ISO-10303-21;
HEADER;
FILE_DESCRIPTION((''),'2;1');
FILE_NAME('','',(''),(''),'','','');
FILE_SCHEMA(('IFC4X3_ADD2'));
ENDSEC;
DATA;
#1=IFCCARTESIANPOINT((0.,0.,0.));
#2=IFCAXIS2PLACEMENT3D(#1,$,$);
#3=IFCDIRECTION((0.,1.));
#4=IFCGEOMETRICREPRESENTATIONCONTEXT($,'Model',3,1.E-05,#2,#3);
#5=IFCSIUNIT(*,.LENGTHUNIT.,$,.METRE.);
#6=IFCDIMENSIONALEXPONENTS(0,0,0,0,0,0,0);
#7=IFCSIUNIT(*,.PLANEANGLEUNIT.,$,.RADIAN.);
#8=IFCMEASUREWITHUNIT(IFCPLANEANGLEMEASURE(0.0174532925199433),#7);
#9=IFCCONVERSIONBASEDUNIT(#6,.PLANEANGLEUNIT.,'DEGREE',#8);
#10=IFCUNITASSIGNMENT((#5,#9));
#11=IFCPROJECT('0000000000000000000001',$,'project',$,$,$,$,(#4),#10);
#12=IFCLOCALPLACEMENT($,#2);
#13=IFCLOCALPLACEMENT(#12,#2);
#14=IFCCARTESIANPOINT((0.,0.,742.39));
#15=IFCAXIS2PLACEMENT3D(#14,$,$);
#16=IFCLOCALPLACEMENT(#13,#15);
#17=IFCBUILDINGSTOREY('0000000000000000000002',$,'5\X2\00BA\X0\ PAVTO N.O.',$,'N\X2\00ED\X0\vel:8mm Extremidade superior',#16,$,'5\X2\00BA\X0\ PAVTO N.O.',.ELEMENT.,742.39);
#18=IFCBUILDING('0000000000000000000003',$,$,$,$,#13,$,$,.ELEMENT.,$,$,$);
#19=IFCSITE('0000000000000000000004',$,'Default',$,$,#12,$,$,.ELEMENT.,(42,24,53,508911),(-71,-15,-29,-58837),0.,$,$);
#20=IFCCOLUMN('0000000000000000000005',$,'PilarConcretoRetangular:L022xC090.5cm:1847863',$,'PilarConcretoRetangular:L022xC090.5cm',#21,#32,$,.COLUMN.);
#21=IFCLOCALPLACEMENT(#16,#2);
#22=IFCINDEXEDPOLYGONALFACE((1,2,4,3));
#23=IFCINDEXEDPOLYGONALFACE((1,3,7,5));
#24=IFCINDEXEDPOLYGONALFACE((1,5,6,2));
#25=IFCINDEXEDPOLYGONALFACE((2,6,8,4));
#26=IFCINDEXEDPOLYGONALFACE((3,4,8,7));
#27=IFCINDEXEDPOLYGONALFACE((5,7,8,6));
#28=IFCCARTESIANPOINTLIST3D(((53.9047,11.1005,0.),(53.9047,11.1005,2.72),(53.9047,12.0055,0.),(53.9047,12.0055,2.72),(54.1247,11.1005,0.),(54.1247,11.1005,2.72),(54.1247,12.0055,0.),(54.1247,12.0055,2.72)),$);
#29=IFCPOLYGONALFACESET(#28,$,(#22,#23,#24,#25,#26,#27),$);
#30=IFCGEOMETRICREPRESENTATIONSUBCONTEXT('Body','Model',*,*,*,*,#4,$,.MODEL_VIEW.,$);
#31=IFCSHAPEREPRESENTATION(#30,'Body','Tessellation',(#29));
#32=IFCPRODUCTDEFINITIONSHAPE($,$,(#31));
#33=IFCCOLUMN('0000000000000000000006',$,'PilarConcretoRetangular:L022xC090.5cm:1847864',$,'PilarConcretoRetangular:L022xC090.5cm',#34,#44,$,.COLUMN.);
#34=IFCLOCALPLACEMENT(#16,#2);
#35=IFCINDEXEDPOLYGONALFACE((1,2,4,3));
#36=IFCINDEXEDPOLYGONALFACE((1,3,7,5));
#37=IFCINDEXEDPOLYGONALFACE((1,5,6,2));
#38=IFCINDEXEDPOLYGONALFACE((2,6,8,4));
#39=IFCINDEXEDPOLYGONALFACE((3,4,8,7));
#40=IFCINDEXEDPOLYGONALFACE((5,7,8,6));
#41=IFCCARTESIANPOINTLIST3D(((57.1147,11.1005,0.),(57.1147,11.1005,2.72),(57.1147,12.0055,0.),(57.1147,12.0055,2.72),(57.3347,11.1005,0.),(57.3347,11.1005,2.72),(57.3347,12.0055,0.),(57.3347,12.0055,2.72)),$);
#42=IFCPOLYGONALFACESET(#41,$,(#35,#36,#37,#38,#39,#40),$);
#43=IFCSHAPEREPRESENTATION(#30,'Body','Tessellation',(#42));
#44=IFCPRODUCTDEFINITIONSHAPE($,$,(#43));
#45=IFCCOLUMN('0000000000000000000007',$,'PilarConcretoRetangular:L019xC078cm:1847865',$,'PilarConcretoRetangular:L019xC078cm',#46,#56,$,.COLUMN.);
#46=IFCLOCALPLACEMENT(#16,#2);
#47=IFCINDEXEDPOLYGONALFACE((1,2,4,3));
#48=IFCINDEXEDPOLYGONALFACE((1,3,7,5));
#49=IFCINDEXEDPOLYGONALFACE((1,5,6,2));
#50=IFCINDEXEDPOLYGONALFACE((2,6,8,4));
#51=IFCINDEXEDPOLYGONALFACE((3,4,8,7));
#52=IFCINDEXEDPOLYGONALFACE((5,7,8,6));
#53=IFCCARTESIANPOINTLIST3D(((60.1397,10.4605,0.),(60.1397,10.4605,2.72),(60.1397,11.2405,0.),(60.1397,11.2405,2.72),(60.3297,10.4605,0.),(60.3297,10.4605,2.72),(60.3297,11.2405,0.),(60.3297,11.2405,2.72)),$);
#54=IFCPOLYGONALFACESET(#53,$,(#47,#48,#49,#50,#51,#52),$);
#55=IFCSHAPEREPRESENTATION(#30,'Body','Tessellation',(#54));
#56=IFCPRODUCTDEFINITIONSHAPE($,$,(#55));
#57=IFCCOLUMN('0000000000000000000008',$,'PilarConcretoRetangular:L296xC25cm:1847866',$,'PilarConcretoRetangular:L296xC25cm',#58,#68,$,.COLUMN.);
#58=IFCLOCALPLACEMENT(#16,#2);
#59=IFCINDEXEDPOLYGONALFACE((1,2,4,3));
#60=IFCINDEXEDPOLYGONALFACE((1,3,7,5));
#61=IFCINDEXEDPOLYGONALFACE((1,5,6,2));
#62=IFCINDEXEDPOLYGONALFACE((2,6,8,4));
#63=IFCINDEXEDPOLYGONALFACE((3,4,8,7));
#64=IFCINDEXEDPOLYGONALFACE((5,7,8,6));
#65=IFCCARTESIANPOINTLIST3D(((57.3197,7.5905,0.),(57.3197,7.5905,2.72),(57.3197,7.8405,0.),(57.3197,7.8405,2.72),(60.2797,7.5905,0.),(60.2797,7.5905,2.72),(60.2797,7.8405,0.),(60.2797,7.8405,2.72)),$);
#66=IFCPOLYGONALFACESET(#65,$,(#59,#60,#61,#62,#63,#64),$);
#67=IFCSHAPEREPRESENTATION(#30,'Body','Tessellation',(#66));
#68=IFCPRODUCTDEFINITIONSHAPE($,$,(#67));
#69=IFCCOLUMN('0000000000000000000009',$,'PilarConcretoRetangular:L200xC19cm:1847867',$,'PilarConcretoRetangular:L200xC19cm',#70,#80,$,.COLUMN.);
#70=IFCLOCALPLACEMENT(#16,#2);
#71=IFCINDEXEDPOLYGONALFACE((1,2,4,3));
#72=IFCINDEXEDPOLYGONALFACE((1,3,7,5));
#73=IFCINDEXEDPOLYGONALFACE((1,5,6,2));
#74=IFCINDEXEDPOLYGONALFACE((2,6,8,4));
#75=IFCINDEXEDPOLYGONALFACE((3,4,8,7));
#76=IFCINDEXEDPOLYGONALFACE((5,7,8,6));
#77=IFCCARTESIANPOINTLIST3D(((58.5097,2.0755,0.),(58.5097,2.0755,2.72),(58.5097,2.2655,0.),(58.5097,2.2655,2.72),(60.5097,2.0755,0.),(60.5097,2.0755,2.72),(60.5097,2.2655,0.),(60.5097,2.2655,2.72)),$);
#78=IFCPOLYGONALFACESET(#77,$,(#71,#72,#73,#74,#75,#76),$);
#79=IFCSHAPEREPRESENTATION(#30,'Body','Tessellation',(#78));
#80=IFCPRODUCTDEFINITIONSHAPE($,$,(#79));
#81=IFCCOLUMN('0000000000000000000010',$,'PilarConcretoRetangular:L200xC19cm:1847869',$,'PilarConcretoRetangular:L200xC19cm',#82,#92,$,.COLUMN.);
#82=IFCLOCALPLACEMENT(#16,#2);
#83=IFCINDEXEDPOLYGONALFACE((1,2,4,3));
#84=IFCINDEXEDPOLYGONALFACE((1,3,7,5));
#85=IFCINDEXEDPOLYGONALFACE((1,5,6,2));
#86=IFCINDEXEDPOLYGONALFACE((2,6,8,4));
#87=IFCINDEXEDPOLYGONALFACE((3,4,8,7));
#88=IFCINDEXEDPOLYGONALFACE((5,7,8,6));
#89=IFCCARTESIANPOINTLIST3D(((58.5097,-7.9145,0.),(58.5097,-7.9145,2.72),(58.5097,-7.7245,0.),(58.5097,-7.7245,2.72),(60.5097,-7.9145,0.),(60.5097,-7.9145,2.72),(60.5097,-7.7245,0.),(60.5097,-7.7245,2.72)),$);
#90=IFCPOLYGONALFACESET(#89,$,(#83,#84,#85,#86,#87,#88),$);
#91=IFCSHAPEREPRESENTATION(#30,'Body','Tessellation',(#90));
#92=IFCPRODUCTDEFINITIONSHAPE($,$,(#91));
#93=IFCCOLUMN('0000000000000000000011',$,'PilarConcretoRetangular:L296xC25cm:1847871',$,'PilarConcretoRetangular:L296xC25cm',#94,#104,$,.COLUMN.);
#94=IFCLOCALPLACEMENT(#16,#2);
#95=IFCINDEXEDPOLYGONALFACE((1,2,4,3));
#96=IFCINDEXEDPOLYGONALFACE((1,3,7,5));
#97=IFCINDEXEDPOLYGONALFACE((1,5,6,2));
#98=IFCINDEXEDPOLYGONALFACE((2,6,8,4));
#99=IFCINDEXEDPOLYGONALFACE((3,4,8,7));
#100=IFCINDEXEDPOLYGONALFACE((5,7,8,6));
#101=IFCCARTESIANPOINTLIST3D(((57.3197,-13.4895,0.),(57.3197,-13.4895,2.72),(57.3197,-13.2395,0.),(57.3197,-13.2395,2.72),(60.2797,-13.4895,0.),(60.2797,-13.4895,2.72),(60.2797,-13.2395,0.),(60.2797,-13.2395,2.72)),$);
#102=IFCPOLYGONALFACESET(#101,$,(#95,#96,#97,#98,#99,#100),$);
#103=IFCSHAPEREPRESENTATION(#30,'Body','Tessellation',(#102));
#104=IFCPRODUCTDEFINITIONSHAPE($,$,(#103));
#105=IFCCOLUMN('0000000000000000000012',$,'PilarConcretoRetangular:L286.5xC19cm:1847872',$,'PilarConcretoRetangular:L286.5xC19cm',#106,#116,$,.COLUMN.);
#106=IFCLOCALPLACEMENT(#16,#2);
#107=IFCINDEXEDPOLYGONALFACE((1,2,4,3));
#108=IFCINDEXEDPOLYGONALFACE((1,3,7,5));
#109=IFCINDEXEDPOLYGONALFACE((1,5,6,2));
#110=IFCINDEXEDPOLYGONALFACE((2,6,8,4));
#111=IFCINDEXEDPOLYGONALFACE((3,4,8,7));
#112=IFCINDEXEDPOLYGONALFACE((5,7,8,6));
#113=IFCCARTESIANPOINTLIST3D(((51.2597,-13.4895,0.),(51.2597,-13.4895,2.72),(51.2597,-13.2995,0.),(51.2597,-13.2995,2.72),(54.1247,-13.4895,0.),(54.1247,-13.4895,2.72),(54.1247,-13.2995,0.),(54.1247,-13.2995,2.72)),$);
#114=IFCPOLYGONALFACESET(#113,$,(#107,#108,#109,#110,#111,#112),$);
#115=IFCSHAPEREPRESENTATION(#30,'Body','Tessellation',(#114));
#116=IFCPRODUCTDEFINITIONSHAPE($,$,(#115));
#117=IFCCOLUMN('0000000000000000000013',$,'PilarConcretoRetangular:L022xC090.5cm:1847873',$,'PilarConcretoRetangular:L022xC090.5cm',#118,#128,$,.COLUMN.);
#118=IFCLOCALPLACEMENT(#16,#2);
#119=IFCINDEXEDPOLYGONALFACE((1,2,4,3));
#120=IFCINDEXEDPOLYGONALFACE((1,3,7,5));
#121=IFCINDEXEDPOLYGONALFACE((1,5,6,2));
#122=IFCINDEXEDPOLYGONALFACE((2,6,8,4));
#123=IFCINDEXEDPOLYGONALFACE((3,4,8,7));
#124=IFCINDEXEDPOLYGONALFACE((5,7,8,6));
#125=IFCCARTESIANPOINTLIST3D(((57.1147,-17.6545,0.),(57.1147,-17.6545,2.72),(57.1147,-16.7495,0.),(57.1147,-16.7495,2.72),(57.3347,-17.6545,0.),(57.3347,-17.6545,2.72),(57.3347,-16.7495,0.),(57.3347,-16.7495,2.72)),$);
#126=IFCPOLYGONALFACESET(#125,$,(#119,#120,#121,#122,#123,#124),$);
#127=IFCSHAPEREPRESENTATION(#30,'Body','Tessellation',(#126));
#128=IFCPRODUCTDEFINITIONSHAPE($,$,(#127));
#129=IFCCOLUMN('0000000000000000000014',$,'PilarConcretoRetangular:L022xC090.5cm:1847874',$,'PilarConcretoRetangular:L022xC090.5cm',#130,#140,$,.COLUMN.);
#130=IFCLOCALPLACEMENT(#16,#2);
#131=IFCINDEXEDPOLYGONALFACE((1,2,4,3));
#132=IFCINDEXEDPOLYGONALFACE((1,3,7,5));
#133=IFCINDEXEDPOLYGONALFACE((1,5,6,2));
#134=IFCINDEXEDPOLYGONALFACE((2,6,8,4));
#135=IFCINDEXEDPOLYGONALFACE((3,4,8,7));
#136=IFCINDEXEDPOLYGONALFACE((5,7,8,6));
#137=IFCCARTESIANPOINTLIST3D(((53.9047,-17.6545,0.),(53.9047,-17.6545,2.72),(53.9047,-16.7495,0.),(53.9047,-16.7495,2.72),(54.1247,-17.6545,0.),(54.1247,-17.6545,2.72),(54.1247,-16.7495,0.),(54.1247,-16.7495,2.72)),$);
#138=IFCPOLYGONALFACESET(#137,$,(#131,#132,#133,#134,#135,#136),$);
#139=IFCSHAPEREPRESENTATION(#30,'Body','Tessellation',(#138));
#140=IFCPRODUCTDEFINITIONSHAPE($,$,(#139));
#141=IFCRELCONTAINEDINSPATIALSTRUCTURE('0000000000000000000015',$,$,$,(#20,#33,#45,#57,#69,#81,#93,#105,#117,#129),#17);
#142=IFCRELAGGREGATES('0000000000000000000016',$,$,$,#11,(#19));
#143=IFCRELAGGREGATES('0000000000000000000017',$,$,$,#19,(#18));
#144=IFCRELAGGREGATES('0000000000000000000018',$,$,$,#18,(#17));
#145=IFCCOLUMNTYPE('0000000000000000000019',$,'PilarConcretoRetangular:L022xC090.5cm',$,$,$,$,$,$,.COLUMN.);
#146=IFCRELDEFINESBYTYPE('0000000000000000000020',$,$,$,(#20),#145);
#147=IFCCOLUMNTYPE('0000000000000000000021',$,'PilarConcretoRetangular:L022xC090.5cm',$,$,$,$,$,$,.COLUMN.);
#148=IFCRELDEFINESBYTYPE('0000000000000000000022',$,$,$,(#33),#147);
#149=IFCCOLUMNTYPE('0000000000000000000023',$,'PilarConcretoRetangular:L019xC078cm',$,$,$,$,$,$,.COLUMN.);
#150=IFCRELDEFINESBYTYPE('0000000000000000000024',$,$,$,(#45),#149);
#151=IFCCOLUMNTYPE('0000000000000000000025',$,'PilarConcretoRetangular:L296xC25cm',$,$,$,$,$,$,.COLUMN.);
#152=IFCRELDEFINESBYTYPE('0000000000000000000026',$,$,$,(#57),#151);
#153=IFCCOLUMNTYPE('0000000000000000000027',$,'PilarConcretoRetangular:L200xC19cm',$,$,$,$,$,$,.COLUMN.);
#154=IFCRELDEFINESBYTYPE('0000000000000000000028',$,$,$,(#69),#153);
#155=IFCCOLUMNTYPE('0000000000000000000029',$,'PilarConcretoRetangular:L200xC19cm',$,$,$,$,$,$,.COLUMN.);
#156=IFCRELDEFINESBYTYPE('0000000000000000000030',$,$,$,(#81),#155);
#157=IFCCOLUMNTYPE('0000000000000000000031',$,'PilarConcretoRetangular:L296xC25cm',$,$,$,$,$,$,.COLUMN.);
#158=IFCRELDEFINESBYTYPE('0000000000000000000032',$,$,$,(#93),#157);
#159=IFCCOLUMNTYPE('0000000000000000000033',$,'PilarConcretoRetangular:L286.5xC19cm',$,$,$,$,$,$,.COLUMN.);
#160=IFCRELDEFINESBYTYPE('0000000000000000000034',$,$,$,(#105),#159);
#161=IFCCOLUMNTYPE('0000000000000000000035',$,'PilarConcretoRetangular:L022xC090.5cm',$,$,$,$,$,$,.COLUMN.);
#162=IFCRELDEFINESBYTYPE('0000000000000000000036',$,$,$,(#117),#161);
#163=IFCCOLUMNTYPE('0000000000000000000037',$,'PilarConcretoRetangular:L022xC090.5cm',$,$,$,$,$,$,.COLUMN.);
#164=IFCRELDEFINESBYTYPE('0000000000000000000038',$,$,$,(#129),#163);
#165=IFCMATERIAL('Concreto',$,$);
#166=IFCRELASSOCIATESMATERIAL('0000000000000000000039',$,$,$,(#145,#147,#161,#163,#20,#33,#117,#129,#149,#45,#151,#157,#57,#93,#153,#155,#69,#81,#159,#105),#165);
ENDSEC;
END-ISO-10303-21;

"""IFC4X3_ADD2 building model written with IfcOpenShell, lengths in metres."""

from ifc_helpers import new_model, entity, si_unit, converted_unit, direction, frame, frame_2d, origin, origin_2d_with_axis, place, context, subcontext, project, spatial, rectangle, extrude, source, transform, mapped, material, material_profile, profile_set, profile_usage, type_object, type_shapes, element, save


model = new_model("IFC4X3_ADD2")

# Units and contexts
model_context = context("Model", 3, precision=1e-05, world=origin(), true_north=direction((0.0, 1.0)))
body_context = subcontext(model_context, "Body", "Model", "MODEL_VIEW")
ifc_project = project(units=[si_unit("LENGTHUNIT", "METRE"), converted_unit("PLANEANGLEUNIT", "DEGREE", entity("IfcPlaneAngleMeasure", 0.0174532925199433), si_unit("PLANEANGLEUNIT", "RADIAN"), dimensions=[0, 0, 0, 0, 0, 0, 0])], contexts=[model_context])

# Site, building, storey
site_placement = place(None, origin())
site = spatial("IfcSite", under=ifc_project, at=site_placement, Name="Default", CompositionType="ELEMENT", RefLatitude=(42, 24, 53, 508911), RefLongitude=(-71, -15, -29, -58837), RefElevation=0.0)
building_placement = place(site_placement, origin())
building = spatial("IfcBuilding", under=site, at=building_placement, CompositionType="ELEMENT")
storey_placement = place(building_placement, frame((0.0, 0.0, 742.39)))
storey = spatial("IfcBuildingStorey", under=building, at=storey_placement, Name="5º PAVTO N.O.", ObjectType="Nível:8mm Extremidade superior", LongName="5º PAVTO N.O.", CompositionType="ELEMENT", Elevation=742.39)

# Columns
ifc_material = material(Name="Concreto")
ifc_material_profile_1 = material_profile(ifc_material, rectangle(XDim=0.22, YDim=0.905, at=frame_2d((0.0, 0.0), x_axis=(1.0, 0.0))), Name="L022xC090.5cm")
ifc_profile_set_1 = profile_set([ifc_material_profile_1], Name="L022xC090.5cm")
ifc_profile_usage_1 = profile_usage(ifc_profile_set_1)
ifc_material_profile_2 = material_profile(ifc_material, rectangle(XDim=2.0, YDim=0.19, at=frame_2d((0.0, 0.0), x_axis=(1.0, 0.0))), Name="L200xC19cm")
ifc_profile_set_2 = profile_set([ifc_material_profile_2], Name="L200xC19cm")
ifc_profile_usage_2 = profile_usage(ifc_profile_set_2)
ifc_material_profile_3 = material_profile(ifc_material, rectangle(XDim=2.96, YDim=0.25, at=frame_2d((0.0, 0.0), x_axis=(1.0, 0.0))), Name="L296xC25cm")
ifc_profile_set_3 = profile_set([ifc_material_profile_3], Name="L296xC25cm")
ifc_profile_usage_3 = profile_usage(ifc_profile_set_3)
ifc_material_profile_4 = material_profile(ifc_material, rectangle(XDim=2.865, YDim=0.19, at=frame_2d((0.0, 0.0), x_axis=(1.0, 0.0))), Name="L286.5xC19cm")
ifc_profile_set_4 = profile_set([ifc_material_profile_4], Name="L286.5xC19cm")
ifc_profile_usage_4 = profile_usage(ifc_profile_set_4)
column_type_1 = type_object("IfcColumnType", Name="PilarConcretoRetangular:L022xC090.5cm", PredefinedType="COLUMN", material=ifc_profile_set_1)
shared_shape_1 = source(origin(), body_context, "Body", "SweptSolid", [
    extrude(rectangle(XDim=0.22, YDim=0.905, at=frame_2d((0.0, 0.0), x_axis=(1.0, 0.0))), frame((54.0147, 11.553, 742.39)), (0.0, 0.0, 1.0), 2.72),
])
type_shapes(column_type_1, [shared_shape_1])
column_1_placement = place(storey_placement, frame((0.0, 0.0, -742.39)))
element("IfcColumn", 1, at=column_1_placement, inside=storey, type_object=column_type_1, material=ifc_profile_usage_1, Name="PilarConcretoRetangular:L022xC090.5cm:1847863", ObjectType="PilarConcretoRetangular:L022xC090.5cm", PredefinedType="COLUMN", context=body_context, shape_type="MappedRepresentation", body=[
    mapped(shared_shape_1, transform((0.0, 0.0, 0.0), scale=1.0)),
])
column_type_2 = type_object("IfcColumnType", Name="PilarConcretoRetangular:L022xC090.5cm", PredefinedType="COLUMN", material=ifc_profile_set_1)
shared_shape_2 = source(origin(), body_context, "Body", "SweptSolid", [
    extrude(rectangle(XDim=0.22, YDim=0.905, at=frame_2d((0.0, 0.0), x_axis=(1.0, 0.0))), frame((57.2247, 11.553, 742.39)), (0.0, 0.0, 1.0), 2.72),
])
type_shapes(column_type_2, [shared_shape_2])
column_2_placement = place(storey_placement, frame((0.0, 0.0, -742.39)))
element("IfcColumn", 2, at=column_2_placement, inside=storey, type_object=column_type_2, material=ifc_profile_usage_1, Name="PilarConcretoRetangular:L022xC090.5cm:1847864", ObjectType="PilarConcretoRetangular:L022xC090.5cm", PredefinedType="COLUMN", context=body_context, shape_type="MappedRepresentation", body=[
    mapped(shared_shape_2, transform((0.0, 0.0, 0.0), scale=1.0)),
])
ifc_material_profile_5 = material_profile(ifc_material, rectangle(XDim=0.19, YDim=0.78, at=frame_2d((0.0, 0.0), x_axis=(1.0, 0.0))), Name="L019xC078cm")
ifc_profile_set_5 = profile_set([ifc_material_profile_5], Name="L019xC078cm")
ifc_profile_usage_5 = profile_usage(ifc_profile_set_5)
column_type_3 = type_object("IfcColumnType", Name="PilarConcretoRetangular:L019xC078cm", PredefinedType="COLUMN", material=ifc_profile_set_5)
shared_shape_3 = source(origin(), body_context, "Body", "SweptSolid", [
    extrude(rectangle(XDim=0.19, YDim=0.78, at=frame_2d((0.0, 0.0), x_axis=(1.0, 0.0))), frame((60.2347, 10.8505, 742.39)), (0.0, 0.0, 1.0), 2.72),
])
type_shapes(column_type_3, [shared_shape_3])
column_3_placement = place(storey_placement, frame((0.0, 0.0, -742.39)))
element("IfcColumn", 3, at=column_3_placement, inside=storey, type_object=column_type_3, material=ifc_profile_usage_5, Name="PilarConcretoRetangular:L019xC078cm:1847865", ObjectType="PilarConcretoRetangular:L019xC078cm", PredefinedType="COLUMN", context=body_context, shape_type="MappedRepresentation", body=[
    mapped(shared_shape_3, transform((0.0, 0.0, 0.0), scale=1.0)),
])
column_type_4 = type_object("IfcColumnType", Name="PilarConcretoRetangular:L296xC25cm", PredefinedType="COLUMN", material=ifc_profile_set_3)
shared_shape_4 = source(origin(), body_context, "Body", "SweptSolid", [
    extrude(rectangle(XDim=2.96, YDim=0.25, at=frame_2d((0.0, 0.0), x_axis=(1.0, 0.0))), frame((58.7997, 7.7155, 742.39), z_axis=(0.0, 0.0, 1.0), x_axis=(-1.0, 0.0, 0.0)), (0.0, 0.0, 1.0), 2.72),
])
type_shapes(column_type_4, [shared_shape_4])
column_4_placement = place(storey_placement, frame((0.0, 0.0, -742.39)))
element("IfcColumn", 4, at=column_4_placement, inside=storey, type_object=column_type_4, material=ifc_profile_usage_3, Name="PilarConcretoRetangular:L296xC25cm:1847866", ObjectType="PilarConcretoRetangular:L296xC25cm", PredefinedType="COLUMN", context=body_context, shape_type="MappedRepresentation", body=[
    mapped(shared_shape_4, transform((0.0, 0.0, 0.0), scale=1.0)),
])
column_type_5 = type_object("IfcColumnType", Name="PilarConcretoRetangular:L200xC19cm", PredefinedType="COLUMN", material=ifc_profile_set_2)
shared_shape_5 = source(origin(), body_context, "Body", "SweptSolid", [
    extrude(rectangle(XDim=2.0, YDim=0.19, at=origin_2d_with_axis()), frame((59.5097, 2.1705, 742.39), z_axis=(0.0, 0.0, 1.0), x_axis=(-1.0, 0.0, 0.0)), (0.0, 0.0, 1.0), 2.72),
])
type_shapes(column_type_5, [shared_shape_5])
column_5_placement = place(storey_placement, frame((0.0, 0.0, -742.39)))
element("IfcColumn", 5, at=column_5_placement, inside=storey, type_object=column_type_5, material=ifc_profile_usage_2, Name="PilarConcretoRetangular:L200xC19cm:1847867", ObjectType="PilarConcretoRetangular:L200xC19cm", PredefinedType="COLUMN", context=body_context, shape_type="MappedRepresentation", body=[
    mapped(shared_shape_5, transform((0.0, 0.0, 0.0), scale=1.0)),
])
column_type_6 = type_object("IfcColumnType", Name="PilarConcretoRetangular:L200xC19cm", PredefinedType="COLUMN", material=ifc_profile_set_2)
shared_shape_6 = source(origin(), body_context, "Body", "SweptSolid", [
    extrude(rectangle(XDim=2.0, YDim=0.19, at=origin_2d_with_axis()), frame((59.5097, -7.8195, 742.39), z_axis=(0.0, 0.0, 1.0), x_axis=(-1.0, 0.0, 0.0)), (0.0, 0.0, 1.0), 2.72),
])
type_shapes(column_type_6, [shared_shape_6])
column_6_placement = place(storey_placement, frame((0.0, 0.0, -742.39)))
element("IfcColumn", 6, at=column_6_placement, inside=storey, type_object=column_type_6, material=ifc_profile_usage_2, Name="PilarConcretoRetangular:L200xC19cm:1847869", ObjectType="PilarConcretoRetangular:L200xC19cm", PredefinedType="COLUMN", context=body_context, shape_type="MappedRepresentation", body=[
    mapped(shared_shape_6, transform((0.0, 0.0, 0.0), scale=1.0)),
])
column_type_7 = type_object("IfcColumnType", Name="PilarConcretoRetangular:L296xC25cm", PredefinedType="COLUMN", material=ifc_profile_set_3)
shared_shape_7 = source(origin(), body_context, "Body", "SweptSolid", [
    extrude(rectangle(XDim=2.96, YDim=0.25, at=frame_2d((0.0, 0.0), x_axis=(1.0, 0.0))), frame((58.7997, -13.3645, 742.39), z_axis=(0.0, 0.0, 1.0), x_axis=(-1.0, 0.0, 0.0)), (0.0, 0.0, 1.0), 2.72),
])
type_shapes(column_type_7, [shared_shape_7])
column_7_placement = place(storey_placement, frame((0.0, 0.0, -742.39)))
element("IfcColumn", 7, at=column_7_placement, inside=storey, type_object=column_type_7, material=ifc_profile_usage_3, Name="PilarConcretoRetangular:L296xC25cm:1847871", ObjectType="PilarConcretoRetangular:L296xC25cm", PredefinedType="COLUMN", context=body_context, shape_type="MappedRepresentation", body=[
    mapped(shared_shape_7, transform((0.0, 0.0, 0.0), scale=1.0)),
])
column_type_8 = type_object("IfcColumnType", Name="PilarConcretoRetangular:L286.5xC19cm", PredefinedType="COLUMN", material=ifc_profile_set_4)
shared_shape_8 = source(origin(), body_context, "Body", "SweptSolid", [
    extrude(rectangle(XDim=2.865, YDim=0.19, at=frame_2d((0.0, 0.0), x_axis=(1.0, 0.0))), frame((52.6922, -13.3945, 742.39), z_axis=(0.0, 0.0, 1.0), x_axis=(-1.0, 0.0, 0.0)), (0.0, 0.0, 1.0), 2.72),
])
type_shapes(column_type_8, [shared_shape_8])
column_8_placement = place(storey_placement, frame((0.0, 0.0, -742.39)))
element("IfcColumn", 8, at=column_8_placement, inside=storey, type_object=column_type_8, material=ifc_profile_usage_4, Name="PilarConcretoRetangular:L286.5xC19cm:1847872", ObjectType="PilarConcretoRetangular:L286.5xC19cm", PredefinedType="COLUMN", context=body_context, shape_type="MappedRepresentation", body=[
    mapped(shared_shape_8, transform((0.0, 0.0, 0.0), scale=1.0)),
])
column_type_9 = type_object("IfcColumnType", Name="PilarConcretoRetangular:L022xC090.5cm", PredefinedType="COLUMN", material=ifc_profile_set_1)
shared_shape_9 = source(origin(), body_context, "Body", "SweptSolid", [
    extrude(rectangle(XDim=0.22, YDim=0.905, at=frame_2d((0.0, 0.0), x_axis=(1.0, 0.0))), frame((57.2247, -17.202, 742.39), z_axis=(0.0, 0.0, 1.0), x_axis=(-1.0, 0.0, 0.0)), (0.0, 0.0, 1.0), 2.72),
])
type_shapes(column_type_9, [shared_shape_9])
column_9_placement = place(storey_placement, frame((0.0, 0.0, -742.39)))
element("IfcColumn", 9, at=column_9_placement, inside=storey, type_object=column_type_9, material=ifc_profile_usage_1, Name="PilarConcretoRetangular:L022xC090.5cm:1847873", ObjectType="PilarConcretoRetangular:L022xC090.5cm", PredefinedType="COLUMN", context=body_context, shape_type="MappedRepresentation", body=[
    mapped(shared_shape_9, transform((0.0, 0.0, 0.0), scale=1.0)),
])
column_type_10 = type_object("IfcColumnType", Name="PilarConcretoRetangular:L022xC090.5cm", PredefinedType="COLUMN", material=ifc_profile_set_1)
shared_shape_10 = source(origin(), body_context, "Body", "SweptSolid", [
    extrude(rectangle(XDim=0.22, YDim=0.905, at=frame_2d((0.0, 0.0), x_axis=(1.0, 0.0))), frame((54.0147, -17.202, 742.39), z_axis=(0.0, 0.0, 1.0), x_axis=(-1.0, 0.0, 0.0)), (0.0, 0.0, 1.0), 2.72),
])
type_shapes(column_type_10, [shared_shape_10])
column_10_placement = place(storey_placement, frame((0.0, 0.0, -742.39)))
element("IfcColumn", 10, at=column_10_placement, inside=storey, type_object=column_type_10, material=ifc_profile_usage_1, Name="PilarConcretoRetangular:L022xC090.5cm:1847874", ObjectType="PilarConcretoRetangular:L022xC090.5cm", PredefinedType="COLUMN", context=body_context, shape_type="MappedRepresentation", body=[
    mapped(shared_shape_10, transform((0.0, 0.0, 0.0), scale=1.0)),
])

save(model, "model.ifc")
